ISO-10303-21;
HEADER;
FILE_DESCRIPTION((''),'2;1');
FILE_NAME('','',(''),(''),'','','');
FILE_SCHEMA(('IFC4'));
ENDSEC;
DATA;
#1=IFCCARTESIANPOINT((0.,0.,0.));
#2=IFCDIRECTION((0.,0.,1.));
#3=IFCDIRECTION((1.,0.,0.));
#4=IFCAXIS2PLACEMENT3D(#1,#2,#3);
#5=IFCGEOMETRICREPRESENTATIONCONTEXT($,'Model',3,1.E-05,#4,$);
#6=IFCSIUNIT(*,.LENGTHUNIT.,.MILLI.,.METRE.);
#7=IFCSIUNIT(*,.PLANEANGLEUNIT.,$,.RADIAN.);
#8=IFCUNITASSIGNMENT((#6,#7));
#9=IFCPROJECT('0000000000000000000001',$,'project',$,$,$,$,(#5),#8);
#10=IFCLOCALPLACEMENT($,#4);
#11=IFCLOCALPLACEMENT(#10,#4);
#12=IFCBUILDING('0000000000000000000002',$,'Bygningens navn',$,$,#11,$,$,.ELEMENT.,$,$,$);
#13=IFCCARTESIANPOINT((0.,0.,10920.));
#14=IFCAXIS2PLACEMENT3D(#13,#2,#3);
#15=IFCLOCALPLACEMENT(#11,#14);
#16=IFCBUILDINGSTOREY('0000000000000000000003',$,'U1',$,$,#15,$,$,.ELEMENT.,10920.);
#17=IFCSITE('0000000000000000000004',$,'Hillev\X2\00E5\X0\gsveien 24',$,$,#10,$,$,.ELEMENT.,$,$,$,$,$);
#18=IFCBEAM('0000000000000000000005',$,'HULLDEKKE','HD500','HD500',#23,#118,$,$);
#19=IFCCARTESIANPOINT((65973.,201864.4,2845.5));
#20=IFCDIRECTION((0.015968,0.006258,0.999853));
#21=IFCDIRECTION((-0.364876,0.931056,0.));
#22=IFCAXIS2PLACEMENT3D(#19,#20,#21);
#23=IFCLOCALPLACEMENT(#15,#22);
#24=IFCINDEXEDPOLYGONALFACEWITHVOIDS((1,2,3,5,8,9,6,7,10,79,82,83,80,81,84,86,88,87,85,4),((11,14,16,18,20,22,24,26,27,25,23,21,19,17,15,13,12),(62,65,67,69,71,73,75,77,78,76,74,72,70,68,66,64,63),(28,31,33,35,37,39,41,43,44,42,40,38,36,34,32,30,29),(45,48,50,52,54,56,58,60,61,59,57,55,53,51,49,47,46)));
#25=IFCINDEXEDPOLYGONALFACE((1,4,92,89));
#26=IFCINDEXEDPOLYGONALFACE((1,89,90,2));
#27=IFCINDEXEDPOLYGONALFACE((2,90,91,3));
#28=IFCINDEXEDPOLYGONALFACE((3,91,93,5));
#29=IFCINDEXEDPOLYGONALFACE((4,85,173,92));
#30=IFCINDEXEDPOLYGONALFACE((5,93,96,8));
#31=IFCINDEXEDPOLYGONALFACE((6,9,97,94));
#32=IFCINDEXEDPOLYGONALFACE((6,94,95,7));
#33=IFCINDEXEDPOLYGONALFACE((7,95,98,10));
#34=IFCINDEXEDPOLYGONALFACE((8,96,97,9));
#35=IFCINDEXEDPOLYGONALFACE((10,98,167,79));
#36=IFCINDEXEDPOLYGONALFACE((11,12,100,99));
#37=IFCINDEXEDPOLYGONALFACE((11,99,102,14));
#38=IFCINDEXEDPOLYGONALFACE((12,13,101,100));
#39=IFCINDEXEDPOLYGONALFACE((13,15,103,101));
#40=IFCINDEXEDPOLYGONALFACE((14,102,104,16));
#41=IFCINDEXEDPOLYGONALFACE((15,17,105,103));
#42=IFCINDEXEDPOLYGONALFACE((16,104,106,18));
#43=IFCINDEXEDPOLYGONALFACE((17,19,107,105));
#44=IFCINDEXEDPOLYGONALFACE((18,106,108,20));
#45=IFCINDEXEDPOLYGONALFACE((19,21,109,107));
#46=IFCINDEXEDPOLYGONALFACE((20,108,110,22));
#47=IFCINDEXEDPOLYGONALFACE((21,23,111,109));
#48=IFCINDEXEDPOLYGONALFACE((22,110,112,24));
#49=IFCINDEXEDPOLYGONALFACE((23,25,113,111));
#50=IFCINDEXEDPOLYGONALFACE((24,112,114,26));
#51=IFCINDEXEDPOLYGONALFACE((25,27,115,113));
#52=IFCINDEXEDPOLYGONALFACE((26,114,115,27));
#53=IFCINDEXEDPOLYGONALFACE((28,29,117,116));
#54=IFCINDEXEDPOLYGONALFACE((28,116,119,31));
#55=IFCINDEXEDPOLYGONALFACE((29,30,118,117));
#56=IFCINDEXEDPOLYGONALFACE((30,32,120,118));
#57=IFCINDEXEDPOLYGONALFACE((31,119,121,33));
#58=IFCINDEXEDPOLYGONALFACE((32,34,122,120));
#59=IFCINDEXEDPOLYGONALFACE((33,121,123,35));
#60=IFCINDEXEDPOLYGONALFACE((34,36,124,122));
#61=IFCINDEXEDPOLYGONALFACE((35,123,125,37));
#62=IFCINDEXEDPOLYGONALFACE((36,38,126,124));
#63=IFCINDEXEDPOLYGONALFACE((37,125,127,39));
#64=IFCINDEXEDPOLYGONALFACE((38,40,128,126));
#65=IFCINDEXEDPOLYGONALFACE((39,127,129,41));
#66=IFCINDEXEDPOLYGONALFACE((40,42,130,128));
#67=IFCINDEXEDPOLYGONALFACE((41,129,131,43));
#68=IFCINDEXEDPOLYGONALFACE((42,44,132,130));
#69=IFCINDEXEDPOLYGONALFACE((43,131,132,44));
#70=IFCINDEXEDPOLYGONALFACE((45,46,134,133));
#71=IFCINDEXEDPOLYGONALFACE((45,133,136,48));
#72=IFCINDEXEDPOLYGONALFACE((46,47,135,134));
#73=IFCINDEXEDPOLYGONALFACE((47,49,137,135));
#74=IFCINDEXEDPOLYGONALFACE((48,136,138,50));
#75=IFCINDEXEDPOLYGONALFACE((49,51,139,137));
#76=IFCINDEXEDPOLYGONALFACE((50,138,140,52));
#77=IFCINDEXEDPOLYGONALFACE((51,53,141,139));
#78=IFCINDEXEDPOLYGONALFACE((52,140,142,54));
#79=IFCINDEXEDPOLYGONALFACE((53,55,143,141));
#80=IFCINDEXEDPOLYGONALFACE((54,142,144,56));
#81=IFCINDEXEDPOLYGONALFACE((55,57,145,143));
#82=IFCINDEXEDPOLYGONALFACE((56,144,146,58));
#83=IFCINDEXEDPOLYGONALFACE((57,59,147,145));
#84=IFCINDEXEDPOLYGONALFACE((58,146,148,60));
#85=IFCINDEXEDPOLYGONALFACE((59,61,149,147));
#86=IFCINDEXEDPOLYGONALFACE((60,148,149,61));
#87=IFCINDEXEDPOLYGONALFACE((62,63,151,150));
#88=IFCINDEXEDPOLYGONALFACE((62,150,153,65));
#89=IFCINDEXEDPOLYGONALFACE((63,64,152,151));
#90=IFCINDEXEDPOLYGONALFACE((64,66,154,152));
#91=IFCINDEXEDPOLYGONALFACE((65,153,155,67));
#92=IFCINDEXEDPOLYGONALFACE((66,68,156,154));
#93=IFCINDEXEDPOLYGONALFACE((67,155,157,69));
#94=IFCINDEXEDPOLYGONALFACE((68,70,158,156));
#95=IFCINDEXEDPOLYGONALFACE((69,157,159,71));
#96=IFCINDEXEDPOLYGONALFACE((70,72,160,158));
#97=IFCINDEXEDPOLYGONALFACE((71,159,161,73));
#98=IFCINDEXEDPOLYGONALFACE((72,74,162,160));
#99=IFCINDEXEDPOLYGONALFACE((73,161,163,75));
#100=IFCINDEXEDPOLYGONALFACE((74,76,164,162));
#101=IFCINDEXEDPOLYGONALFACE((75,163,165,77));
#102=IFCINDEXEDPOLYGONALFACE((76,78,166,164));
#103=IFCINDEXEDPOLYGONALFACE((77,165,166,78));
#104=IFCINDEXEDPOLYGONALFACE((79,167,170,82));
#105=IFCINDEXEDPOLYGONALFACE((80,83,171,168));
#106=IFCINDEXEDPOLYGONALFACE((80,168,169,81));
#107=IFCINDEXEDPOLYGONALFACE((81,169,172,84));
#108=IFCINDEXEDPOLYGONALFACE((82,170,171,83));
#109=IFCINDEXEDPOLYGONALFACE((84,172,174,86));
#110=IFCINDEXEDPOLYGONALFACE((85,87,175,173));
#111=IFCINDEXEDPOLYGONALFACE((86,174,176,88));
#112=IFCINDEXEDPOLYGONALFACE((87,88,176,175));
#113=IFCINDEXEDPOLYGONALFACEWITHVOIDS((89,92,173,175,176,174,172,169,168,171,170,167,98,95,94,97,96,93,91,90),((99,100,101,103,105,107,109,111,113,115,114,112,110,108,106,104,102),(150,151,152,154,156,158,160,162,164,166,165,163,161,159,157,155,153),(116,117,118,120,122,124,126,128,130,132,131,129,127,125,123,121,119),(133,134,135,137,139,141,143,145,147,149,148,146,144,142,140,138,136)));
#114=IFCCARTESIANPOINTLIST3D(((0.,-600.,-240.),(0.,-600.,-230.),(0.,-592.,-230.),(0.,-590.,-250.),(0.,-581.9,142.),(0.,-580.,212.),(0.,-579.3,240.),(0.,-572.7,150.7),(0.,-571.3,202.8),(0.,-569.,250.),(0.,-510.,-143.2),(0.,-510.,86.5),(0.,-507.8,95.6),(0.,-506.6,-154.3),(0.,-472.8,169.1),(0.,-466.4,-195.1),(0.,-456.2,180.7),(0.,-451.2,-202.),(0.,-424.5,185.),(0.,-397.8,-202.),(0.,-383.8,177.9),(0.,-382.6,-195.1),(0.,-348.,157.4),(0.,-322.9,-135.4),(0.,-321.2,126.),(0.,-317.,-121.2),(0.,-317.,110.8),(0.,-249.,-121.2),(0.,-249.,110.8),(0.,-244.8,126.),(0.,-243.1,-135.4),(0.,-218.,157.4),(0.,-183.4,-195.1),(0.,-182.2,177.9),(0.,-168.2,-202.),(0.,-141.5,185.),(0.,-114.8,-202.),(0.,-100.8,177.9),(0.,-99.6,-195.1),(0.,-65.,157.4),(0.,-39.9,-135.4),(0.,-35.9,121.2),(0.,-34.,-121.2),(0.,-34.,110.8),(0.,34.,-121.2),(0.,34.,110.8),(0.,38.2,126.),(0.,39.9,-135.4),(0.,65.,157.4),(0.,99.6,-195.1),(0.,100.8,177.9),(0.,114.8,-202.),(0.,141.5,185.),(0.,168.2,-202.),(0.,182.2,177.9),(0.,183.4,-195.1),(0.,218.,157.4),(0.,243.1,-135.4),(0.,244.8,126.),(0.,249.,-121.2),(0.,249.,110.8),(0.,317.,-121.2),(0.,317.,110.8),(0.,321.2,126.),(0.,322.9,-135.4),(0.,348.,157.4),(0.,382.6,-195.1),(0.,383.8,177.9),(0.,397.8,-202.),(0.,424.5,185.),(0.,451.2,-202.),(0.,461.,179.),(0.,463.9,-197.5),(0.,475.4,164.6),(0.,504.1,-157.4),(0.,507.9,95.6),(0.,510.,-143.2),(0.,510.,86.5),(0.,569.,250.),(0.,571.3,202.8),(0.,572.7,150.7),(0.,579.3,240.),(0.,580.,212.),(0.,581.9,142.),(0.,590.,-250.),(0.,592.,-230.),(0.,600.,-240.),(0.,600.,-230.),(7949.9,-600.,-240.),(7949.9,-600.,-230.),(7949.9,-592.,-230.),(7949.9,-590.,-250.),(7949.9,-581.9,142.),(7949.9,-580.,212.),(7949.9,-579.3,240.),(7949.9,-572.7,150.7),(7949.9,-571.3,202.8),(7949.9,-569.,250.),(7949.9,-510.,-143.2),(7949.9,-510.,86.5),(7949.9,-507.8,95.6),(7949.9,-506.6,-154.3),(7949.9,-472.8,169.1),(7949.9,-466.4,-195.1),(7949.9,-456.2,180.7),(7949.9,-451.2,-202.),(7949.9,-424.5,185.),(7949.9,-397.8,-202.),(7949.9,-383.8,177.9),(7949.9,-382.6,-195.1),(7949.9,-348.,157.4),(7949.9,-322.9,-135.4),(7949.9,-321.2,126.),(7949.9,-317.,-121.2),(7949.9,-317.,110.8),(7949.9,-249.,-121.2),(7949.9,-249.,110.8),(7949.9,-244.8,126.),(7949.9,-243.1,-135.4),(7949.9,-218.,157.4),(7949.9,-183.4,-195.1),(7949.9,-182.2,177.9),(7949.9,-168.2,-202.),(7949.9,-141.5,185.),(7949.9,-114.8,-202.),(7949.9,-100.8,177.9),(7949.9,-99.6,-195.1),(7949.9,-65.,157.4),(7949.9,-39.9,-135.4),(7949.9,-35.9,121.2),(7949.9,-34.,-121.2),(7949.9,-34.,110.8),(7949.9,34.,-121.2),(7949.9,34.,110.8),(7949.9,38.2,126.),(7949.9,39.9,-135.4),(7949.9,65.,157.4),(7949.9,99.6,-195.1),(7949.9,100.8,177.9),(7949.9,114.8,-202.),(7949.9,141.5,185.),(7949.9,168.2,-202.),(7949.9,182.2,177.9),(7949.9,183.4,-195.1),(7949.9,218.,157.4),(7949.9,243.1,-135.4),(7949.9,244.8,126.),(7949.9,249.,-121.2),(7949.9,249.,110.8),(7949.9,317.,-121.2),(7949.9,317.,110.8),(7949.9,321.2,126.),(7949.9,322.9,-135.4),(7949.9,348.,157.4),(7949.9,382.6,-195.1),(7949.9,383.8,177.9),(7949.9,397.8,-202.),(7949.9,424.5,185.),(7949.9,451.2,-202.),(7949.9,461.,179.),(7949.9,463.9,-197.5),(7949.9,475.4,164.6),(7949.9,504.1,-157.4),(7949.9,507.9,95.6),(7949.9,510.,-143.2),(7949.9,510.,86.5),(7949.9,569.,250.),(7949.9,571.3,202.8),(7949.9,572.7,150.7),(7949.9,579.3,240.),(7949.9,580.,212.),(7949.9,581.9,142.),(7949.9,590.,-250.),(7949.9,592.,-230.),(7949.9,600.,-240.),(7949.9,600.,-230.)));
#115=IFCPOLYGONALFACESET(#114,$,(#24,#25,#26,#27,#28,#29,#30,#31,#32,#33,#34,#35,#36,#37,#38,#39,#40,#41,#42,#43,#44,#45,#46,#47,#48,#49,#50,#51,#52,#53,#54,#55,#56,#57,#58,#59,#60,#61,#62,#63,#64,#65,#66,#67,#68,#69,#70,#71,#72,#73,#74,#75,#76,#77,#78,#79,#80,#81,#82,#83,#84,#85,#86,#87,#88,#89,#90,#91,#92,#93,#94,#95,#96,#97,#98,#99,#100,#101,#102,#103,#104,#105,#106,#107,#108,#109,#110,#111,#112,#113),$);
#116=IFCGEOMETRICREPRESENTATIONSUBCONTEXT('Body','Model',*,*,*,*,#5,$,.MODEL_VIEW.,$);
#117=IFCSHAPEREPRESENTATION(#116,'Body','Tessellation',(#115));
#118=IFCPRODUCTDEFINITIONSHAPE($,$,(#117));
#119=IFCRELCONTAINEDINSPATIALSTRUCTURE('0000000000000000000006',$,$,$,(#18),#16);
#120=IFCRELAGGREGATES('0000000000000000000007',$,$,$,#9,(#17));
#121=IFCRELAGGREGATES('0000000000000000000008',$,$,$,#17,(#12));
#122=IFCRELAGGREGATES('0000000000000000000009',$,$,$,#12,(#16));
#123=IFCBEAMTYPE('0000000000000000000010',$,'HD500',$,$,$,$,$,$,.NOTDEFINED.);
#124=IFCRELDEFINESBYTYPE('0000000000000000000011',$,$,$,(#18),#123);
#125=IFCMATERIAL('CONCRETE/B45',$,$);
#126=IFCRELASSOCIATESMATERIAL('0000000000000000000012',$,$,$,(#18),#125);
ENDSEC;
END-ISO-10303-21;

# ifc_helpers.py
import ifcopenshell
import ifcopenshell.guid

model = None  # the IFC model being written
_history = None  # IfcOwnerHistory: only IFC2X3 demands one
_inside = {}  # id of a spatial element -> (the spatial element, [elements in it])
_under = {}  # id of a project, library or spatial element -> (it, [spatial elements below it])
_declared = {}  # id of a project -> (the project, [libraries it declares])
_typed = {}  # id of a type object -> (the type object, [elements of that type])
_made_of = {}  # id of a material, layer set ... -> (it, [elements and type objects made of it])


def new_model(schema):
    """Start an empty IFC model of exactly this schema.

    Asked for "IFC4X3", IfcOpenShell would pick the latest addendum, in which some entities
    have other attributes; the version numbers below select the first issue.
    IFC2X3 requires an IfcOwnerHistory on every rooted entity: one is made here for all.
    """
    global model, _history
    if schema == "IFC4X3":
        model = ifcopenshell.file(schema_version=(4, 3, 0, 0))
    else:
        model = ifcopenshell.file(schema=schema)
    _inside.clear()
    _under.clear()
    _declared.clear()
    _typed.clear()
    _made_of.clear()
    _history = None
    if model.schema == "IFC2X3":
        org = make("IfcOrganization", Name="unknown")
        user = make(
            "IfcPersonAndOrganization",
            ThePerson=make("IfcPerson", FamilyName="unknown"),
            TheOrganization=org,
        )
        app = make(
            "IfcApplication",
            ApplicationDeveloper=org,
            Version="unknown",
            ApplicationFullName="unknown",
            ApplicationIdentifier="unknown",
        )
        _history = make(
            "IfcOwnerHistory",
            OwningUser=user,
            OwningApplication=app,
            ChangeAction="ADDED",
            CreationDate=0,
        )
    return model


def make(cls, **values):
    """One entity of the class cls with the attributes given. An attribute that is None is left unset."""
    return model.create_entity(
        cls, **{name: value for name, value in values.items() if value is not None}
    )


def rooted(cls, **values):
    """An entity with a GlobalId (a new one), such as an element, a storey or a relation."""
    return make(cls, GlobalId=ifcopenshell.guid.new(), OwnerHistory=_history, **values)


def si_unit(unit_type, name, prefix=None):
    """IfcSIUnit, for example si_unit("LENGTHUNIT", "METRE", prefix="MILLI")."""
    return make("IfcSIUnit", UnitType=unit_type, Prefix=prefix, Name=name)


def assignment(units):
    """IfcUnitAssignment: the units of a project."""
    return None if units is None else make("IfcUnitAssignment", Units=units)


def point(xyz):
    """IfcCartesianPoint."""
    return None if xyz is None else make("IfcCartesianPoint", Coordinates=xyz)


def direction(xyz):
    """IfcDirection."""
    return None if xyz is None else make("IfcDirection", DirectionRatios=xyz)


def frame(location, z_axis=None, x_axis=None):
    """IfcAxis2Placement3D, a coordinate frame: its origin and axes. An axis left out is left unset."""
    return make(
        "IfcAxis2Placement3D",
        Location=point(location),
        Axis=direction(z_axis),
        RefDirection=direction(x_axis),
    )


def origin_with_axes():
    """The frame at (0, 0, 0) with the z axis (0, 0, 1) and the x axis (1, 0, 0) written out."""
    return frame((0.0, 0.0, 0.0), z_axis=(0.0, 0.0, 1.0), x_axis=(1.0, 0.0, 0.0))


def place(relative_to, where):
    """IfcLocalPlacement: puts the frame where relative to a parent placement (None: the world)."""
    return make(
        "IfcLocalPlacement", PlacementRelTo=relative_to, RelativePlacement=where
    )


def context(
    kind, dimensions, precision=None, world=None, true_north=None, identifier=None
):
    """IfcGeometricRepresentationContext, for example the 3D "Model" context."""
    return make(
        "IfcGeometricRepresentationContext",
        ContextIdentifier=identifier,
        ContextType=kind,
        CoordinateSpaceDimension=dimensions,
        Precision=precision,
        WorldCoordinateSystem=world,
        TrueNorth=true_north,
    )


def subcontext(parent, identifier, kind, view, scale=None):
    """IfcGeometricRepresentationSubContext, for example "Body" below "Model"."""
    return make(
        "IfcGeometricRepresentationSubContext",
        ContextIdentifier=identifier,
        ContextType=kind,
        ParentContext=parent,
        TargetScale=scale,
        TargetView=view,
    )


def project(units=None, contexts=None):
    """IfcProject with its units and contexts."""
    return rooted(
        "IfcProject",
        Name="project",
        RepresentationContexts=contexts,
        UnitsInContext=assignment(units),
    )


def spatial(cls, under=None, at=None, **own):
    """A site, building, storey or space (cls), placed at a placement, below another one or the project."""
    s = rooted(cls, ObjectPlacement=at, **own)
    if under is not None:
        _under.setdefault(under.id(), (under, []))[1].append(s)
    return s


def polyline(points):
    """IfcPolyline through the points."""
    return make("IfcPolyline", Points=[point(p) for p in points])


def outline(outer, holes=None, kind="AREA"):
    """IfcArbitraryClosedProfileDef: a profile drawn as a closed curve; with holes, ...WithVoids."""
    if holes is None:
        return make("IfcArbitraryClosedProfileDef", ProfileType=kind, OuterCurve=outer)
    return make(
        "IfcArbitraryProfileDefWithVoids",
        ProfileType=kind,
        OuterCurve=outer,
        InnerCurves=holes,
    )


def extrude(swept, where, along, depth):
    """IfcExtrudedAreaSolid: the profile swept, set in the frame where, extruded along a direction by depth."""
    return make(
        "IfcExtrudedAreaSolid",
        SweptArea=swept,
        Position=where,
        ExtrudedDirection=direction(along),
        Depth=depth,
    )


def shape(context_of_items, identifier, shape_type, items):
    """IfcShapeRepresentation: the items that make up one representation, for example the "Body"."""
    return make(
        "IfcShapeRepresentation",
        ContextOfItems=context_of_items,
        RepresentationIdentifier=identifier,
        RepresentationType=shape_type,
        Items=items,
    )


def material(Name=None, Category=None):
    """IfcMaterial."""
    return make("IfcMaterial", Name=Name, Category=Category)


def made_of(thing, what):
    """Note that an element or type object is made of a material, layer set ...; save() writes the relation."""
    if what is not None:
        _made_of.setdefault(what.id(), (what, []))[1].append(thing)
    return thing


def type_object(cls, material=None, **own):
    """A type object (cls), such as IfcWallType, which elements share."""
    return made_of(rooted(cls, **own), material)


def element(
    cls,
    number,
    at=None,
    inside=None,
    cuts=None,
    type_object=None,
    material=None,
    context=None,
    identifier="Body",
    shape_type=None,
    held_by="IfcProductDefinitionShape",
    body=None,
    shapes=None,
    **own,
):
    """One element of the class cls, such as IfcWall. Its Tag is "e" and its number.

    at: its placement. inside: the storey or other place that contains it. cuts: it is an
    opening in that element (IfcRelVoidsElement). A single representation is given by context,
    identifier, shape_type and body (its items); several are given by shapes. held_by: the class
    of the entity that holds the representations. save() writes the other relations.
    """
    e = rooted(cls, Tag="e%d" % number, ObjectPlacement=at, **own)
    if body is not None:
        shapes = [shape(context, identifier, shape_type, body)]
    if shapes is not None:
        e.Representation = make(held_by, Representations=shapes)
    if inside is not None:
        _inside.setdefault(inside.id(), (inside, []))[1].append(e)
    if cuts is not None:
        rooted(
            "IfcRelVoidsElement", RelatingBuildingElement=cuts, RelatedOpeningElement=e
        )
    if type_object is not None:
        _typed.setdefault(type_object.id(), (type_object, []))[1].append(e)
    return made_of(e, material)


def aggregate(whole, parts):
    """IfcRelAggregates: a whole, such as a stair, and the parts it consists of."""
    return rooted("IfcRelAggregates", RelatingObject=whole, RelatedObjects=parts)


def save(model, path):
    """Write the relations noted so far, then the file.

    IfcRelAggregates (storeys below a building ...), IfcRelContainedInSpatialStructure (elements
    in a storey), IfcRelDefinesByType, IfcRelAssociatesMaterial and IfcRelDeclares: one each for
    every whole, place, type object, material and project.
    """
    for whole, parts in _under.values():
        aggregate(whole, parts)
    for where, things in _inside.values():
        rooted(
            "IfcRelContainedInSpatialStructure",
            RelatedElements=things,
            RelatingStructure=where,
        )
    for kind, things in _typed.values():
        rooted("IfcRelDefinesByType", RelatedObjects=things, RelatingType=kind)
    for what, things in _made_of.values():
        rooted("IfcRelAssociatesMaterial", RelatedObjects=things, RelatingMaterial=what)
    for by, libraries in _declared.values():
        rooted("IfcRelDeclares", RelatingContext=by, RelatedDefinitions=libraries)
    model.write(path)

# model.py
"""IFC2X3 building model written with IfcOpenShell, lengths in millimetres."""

from ifc_helpers import new_model, si_unit, frame, origin_with_axes, place, context, subcontext, project, spatial, polyline, outline, extrude, material, type_object, element, save


model = new_model("IFC2X3")

# Units and contexts
model_context = context("Model", 3, precision=1e-05, world=origin_with_axes())
body_context = subcontext(model_context, "Body", "Model", "MODEL_VIEW")
ifc_project = project(units=[si_unit("LENGTHUNIT", "METRE", prefix="MILLI"), si_unit("PLANEANGLEUNIT", "RADIAN")], contexts=[model_context])

# Site, building, storey
site_placement = place(None, origin_with_axes())
site = spatial("IfcSite", under=ifc_project, at=site_placement, Name="Hillevågsveien 24", CompositionType="ELEMENT")
building_placement = place(site_placement, origin_with_axes())
building = spatial("IfcBuilding", under=site, at=building_placement, Name="Bygningens navn", CompositionType="ELEMENT")
storey_placement = place(building_placement, frame((0.0, 0.0, 10920.0), z_axis=(0.0, 0.0, 1.0), x_axis=(1.0, 0.0, 0.0)))
storey = spatial("IfcBuildingStorey", under=building, at=storey_placement, Name="U1", CompositionType="ELEMENT", Elevation=10920.0)

# Beam
ifc_material_1 = material(Name="CONCRETE/B45")
beam_type_1 = type_object("IfcBeamType", Name="HD500", PredefinedType="NOTDEFINED")
beam_1_placement = place(storey_placement, frame((65973.0, 201864.4, 2845.5), z_axis=(0.015968, 0.006258, 0.999853), x_axis=(-0.364876, 0.931056, 0.0)))
element("IfcBeam", 1, at=beam_1_placement, inside=storey, type_object=beam_type_1, material=ifc_material_1, Name="HULLDEKKE", Description="HD500", ObjectType="HD500", context=body_context, shape_type="SweptSolid", body=[
    extrude(outline(polyline([(581.9, 142.0), (592.0, -230.0), (600.0, -230.0), (600.0, -240.0), (590.0, -250.0), (-590.0, -250.0), (-600.0, -240.0), (-600.0, -230.0), (-592.0, -230.0), (-581.9, 142.0), (-572.7, 150.7), (-571.3, 202.8), (-580.0, 212.0), (-579.3, 240.0), (-569.0, 250.0), (569.0, 250.0), (579.3, 240.0), (580.0, 212.0), (571.3, 202.8), (572.7, 150.7), (581.9, 142.0)]), holes=[polyline([(466.4, -195.1), (506.6, -154.3), (510.0, -143.2), (510.0, 86.5), (507.8, 95.6), (472.8, 169.1), (456.2, 180.7), (424.5, 185.0), (383.8, 177.9), (348.0, 157.4), (321.2, 126.0), (317.0, 110.8), (317.0, -121.2), (322.9, -135.4), (382.6, -195.1), (397.8, -202.0), (451.2, -202.0), (466.4, -195.1)]), polyline([(183.4, -195.1), (243.1, -135.4), (249.0, -121.2), (249.0, 110.8), (244.8, 126.0), (218.0, 157.4), (182.2, 177.9), (141.5, 185.0), (100.8, 177.9), (65.0, 157.4), (35.9, 121.2), (34.0, 110.8), (34.0, -121.2), (39.9, -135.4), (99.6, -195.1), (114.8, -202.0), (168.2, -202.0), (183.4, -195.1)]), polyline([(-99.6, -195.1), (-39.9, -135.4), (-34.0, -121.2), (-34.0, 110.8), (-38.2, 126.0), (-65.0, 157.4), (-100.8, 177.9), (-141.5, 185.0), (-182.2, 177.9), (-218.0, 157.4), (-244.8, 126.0), (-249.0, 110.8), (-249.0, -121.2), (-243.1, -135.4), (-183.4, -195.1), (-168.2, -202.0), (-114.8, -202.0), (-99.6, -195.1)]), polyline([(-382.6, -195.1), (-322.9, -135.4), (-317.0, -121.2), (-317.0, 110.8), (-321.2, 126.0), (-348.0, 157.4), (-383.8, 177.9), (-424.5, 185.0), (-461.0, 179.0), (-475.4, 164.6), (-507.9, 95.6), (-510.0, 86.5), (-510.0, -143.2), (-504.1, -157.4), (-463.9, -197.5), (-451.2, -202.0), (-397.8, -202.0), (-382.6, -195.1)])]), frame((7949.9, 0.0, 0.0), z_axis=(-1.0, 0.0, 0.0), x_axis=(0.0, -1.0, 0.0)), (0.0, 0.0, 1.0), 7949.9),
])

save(model, "model.ifc")
